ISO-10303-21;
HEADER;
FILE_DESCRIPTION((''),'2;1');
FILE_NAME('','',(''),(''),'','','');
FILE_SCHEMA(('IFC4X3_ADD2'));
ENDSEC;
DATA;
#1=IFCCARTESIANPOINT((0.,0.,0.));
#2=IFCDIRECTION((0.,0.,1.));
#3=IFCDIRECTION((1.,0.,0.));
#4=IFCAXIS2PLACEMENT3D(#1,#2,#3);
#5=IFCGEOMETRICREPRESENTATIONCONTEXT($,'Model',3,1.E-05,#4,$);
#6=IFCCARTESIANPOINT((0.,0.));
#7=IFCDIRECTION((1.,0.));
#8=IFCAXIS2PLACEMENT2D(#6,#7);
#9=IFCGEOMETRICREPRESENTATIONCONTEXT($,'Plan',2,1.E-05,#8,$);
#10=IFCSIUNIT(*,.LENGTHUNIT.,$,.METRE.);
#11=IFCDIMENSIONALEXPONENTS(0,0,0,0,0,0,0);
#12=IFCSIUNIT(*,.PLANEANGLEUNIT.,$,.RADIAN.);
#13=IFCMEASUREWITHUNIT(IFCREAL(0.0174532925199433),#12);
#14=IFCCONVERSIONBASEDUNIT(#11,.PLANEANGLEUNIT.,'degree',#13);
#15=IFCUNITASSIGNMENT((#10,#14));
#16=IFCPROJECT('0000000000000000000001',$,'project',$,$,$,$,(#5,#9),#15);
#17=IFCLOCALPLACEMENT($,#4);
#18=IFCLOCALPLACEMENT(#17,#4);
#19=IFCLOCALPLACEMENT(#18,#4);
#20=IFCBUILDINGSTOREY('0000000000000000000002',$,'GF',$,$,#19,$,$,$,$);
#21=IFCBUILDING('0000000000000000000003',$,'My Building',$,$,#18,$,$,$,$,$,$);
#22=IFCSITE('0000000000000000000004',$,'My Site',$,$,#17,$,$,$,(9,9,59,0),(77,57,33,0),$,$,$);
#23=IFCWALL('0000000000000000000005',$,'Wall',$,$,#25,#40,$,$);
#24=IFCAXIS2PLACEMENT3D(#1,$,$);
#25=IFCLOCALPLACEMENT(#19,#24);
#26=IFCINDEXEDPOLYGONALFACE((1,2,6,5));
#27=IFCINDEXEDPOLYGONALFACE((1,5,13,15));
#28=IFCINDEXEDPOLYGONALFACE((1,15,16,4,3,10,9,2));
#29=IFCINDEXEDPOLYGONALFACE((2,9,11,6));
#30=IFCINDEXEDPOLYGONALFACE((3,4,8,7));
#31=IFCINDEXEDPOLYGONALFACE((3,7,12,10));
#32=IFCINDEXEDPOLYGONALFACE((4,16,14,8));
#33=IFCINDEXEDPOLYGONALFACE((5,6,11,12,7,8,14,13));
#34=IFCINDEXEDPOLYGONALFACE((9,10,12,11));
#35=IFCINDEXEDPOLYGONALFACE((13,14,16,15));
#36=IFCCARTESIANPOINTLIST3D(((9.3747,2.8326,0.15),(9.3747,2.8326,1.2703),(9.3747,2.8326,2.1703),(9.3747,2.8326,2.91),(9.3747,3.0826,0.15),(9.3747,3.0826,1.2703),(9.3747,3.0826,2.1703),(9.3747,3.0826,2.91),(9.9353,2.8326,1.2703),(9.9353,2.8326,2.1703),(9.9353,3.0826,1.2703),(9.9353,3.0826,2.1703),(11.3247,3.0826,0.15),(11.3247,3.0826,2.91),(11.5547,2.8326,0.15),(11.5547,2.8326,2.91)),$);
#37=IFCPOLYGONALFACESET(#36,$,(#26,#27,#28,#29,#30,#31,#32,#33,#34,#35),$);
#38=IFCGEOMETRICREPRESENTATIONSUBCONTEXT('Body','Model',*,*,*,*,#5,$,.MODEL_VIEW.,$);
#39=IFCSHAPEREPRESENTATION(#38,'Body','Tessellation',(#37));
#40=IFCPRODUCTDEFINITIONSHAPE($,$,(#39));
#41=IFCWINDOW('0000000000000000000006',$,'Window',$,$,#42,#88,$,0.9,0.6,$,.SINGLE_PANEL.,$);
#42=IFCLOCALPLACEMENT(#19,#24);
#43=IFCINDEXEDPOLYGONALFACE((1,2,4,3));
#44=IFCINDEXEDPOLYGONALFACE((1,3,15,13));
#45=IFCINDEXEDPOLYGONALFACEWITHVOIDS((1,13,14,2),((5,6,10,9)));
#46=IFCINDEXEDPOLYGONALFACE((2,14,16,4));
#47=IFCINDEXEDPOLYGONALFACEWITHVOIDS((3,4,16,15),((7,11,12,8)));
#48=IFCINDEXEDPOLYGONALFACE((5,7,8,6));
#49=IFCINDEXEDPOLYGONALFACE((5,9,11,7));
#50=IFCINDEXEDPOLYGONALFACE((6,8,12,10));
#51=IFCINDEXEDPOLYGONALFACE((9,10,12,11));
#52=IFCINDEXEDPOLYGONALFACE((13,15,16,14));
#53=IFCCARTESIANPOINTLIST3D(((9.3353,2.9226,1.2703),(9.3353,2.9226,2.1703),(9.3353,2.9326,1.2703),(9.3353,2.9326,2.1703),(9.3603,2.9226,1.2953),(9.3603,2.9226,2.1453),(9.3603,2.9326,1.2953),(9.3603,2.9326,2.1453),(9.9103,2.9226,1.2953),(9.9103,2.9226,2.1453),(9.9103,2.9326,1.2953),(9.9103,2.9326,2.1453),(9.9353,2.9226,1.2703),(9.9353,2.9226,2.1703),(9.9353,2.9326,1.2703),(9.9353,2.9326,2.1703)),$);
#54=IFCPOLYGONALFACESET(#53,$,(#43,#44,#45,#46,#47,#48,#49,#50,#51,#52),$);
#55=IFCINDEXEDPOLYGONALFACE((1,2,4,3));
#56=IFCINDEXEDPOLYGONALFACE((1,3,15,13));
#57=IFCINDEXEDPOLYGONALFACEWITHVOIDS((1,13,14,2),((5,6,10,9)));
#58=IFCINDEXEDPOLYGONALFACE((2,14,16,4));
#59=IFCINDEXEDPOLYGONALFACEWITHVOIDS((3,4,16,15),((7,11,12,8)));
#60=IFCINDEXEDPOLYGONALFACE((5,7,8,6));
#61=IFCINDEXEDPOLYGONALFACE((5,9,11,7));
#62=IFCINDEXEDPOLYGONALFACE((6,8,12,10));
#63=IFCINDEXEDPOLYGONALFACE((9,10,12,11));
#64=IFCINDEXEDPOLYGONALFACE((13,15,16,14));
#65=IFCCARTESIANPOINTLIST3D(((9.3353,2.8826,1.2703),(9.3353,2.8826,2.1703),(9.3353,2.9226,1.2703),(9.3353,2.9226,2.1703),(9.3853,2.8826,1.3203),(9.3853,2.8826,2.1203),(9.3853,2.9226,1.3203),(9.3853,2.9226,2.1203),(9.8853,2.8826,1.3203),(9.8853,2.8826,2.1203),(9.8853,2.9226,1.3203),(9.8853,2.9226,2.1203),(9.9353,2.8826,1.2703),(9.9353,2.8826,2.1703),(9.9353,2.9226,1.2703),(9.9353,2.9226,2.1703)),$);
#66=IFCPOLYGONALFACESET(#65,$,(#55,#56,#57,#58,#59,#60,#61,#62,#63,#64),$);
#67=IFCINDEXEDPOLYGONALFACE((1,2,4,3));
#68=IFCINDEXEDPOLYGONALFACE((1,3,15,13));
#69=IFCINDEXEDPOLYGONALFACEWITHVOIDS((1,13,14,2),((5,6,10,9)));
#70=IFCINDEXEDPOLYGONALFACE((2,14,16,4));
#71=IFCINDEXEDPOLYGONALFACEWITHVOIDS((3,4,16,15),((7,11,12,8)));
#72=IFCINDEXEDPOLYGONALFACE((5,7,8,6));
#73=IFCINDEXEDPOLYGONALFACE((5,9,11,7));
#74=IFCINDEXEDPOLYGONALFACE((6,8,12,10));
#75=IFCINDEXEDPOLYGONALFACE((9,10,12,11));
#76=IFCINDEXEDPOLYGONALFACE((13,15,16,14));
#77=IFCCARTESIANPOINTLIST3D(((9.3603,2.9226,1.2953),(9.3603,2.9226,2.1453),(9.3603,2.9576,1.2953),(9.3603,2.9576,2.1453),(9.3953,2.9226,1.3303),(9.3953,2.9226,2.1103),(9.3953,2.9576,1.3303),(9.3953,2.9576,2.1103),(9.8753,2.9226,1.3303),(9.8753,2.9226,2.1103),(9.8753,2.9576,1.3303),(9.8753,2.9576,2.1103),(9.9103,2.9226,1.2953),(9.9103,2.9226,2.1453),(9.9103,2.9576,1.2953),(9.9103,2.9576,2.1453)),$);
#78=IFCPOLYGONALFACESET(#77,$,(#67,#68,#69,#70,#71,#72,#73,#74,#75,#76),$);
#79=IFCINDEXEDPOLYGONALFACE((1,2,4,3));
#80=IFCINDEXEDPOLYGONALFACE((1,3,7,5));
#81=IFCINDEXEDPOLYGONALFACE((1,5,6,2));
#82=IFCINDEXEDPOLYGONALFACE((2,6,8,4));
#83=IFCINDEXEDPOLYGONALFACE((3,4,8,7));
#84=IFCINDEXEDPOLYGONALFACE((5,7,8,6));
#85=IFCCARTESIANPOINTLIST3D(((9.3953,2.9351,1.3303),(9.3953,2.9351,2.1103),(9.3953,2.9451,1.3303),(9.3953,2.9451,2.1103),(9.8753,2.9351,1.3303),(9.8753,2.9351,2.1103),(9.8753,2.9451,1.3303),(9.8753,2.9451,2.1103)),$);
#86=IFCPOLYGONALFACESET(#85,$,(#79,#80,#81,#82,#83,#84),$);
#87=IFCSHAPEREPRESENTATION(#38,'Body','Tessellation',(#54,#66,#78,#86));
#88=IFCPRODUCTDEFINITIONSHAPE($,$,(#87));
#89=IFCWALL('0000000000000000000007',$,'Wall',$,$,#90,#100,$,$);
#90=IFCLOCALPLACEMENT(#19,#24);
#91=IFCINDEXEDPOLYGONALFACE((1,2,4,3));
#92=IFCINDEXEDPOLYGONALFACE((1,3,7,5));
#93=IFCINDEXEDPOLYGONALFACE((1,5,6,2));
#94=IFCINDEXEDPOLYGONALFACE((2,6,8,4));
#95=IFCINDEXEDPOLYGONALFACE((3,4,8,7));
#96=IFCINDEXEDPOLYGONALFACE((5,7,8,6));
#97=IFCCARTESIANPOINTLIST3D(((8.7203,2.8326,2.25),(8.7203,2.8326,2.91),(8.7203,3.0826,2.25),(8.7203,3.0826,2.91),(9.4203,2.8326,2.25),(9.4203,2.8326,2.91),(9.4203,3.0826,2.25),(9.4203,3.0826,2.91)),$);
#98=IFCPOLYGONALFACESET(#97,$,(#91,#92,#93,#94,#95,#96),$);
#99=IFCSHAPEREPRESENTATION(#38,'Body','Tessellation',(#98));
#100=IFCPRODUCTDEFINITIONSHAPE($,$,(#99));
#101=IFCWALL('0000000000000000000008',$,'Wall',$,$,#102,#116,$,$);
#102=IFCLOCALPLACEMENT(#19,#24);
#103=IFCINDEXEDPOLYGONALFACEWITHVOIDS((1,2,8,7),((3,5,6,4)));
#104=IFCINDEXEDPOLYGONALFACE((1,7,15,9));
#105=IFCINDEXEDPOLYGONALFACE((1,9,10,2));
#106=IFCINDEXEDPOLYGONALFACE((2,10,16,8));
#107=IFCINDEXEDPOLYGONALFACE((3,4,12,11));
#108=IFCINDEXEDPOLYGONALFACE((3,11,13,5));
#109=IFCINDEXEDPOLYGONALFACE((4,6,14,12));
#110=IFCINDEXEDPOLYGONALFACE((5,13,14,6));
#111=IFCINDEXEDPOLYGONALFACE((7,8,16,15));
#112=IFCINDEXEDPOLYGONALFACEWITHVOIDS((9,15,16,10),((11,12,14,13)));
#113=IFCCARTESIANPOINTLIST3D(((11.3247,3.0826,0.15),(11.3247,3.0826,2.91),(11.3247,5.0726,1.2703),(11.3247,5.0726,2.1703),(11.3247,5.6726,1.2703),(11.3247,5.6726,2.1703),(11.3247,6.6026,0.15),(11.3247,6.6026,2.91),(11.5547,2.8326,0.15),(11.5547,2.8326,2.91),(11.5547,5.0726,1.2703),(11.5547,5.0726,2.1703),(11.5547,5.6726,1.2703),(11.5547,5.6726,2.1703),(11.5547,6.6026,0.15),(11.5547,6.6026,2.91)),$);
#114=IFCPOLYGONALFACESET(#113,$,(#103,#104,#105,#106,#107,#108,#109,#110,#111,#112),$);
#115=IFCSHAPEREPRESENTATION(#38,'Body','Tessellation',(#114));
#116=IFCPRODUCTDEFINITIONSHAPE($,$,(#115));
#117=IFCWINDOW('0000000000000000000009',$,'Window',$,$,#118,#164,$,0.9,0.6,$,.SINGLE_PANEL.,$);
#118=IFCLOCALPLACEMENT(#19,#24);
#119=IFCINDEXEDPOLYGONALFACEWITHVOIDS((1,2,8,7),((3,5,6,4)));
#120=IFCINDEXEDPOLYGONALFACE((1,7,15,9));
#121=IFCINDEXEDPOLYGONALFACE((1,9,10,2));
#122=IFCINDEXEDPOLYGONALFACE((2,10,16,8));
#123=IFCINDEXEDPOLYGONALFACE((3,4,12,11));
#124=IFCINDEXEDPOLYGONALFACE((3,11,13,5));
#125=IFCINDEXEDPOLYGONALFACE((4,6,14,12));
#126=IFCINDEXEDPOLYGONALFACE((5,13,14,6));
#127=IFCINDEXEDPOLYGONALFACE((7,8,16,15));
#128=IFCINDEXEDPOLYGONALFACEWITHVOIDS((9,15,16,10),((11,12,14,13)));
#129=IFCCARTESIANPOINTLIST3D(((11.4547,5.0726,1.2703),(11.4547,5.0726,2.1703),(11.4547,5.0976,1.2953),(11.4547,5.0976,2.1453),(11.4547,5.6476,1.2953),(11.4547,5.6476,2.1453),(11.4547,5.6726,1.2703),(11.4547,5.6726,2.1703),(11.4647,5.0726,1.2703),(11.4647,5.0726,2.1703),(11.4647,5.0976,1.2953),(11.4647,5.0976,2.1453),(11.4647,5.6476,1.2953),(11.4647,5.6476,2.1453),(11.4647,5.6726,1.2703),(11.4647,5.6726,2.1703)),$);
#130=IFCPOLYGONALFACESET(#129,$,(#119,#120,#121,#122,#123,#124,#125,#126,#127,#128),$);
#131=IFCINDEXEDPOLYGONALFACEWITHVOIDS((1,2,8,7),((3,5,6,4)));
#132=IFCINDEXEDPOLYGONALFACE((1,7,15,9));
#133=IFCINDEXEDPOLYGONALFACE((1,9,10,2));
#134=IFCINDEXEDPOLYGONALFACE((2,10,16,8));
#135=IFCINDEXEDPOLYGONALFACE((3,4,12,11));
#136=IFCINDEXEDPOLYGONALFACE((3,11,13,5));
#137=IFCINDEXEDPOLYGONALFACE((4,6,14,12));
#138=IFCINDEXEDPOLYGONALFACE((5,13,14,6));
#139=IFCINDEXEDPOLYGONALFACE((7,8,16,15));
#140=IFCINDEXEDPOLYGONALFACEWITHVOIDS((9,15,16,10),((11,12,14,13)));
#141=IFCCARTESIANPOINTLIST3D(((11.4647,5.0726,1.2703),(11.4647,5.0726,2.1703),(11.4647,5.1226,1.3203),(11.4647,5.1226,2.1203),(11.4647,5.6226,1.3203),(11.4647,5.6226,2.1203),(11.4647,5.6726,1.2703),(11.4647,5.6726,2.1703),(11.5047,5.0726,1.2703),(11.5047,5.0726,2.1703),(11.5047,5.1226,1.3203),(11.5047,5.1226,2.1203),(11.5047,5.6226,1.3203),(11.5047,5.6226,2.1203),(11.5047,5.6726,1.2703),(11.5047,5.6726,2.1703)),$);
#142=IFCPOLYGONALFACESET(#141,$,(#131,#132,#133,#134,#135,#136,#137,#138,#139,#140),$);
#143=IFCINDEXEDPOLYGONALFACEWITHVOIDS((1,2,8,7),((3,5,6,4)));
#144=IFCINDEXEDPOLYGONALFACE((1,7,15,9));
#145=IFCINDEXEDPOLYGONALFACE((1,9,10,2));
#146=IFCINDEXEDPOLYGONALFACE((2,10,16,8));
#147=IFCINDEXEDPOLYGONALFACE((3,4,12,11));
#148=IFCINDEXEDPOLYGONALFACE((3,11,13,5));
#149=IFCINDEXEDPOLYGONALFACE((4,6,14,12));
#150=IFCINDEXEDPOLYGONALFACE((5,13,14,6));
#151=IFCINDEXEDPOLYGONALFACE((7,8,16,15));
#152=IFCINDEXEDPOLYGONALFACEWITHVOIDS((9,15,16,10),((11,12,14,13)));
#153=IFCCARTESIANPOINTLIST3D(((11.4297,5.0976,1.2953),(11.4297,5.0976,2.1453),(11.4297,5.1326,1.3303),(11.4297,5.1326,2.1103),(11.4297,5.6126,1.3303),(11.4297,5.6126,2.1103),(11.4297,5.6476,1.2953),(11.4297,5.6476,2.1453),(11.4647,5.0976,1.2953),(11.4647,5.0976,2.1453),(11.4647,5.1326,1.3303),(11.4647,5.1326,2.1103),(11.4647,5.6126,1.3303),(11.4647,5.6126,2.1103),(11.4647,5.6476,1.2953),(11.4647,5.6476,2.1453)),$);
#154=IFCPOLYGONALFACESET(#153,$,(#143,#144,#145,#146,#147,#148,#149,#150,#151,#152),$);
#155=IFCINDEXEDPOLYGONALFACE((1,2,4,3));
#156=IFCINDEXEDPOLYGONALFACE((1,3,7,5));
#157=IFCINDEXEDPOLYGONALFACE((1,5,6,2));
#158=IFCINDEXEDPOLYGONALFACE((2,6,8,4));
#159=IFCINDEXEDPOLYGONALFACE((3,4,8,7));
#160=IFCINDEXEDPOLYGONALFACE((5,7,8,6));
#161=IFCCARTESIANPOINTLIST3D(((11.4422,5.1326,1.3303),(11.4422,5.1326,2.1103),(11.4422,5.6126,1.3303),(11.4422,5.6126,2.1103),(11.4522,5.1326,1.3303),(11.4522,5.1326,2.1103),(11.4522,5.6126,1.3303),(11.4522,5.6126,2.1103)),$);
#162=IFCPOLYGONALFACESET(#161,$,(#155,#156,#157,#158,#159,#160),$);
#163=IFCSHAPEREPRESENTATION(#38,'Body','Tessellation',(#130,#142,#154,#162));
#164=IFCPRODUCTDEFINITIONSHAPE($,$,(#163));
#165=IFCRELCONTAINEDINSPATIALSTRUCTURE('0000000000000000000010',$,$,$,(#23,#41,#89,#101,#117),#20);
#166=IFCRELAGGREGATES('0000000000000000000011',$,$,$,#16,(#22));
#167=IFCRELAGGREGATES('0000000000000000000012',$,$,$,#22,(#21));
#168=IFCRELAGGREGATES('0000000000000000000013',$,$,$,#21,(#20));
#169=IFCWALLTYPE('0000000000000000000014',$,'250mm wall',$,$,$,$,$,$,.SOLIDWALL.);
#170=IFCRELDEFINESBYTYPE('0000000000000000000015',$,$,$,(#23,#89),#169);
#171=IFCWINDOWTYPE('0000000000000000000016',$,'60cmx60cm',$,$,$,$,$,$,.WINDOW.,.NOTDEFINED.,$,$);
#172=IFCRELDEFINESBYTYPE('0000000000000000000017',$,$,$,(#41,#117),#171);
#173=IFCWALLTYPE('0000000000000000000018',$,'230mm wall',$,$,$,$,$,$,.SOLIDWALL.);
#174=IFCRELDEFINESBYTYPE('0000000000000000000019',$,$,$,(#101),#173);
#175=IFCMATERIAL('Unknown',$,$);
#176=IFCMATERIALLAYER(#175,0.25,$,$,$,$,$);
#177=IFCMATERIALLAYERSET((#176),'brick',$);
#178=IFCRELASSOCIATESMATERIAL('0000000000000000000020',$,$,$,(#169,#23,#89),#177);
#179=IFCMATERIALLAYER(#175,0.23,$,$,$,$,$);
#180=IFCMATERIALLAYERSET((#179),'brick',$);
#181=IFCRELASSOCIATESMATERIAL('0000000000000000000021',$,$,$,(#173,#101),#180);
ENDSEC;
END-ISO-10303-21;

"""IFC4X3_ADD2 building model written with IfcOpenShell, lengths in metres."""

from ifc_helpers import new_model, entity, si_unit, converted_unit, frame, origin_with_axes, origin_2d_with_axis, place, context, subcontext, project, spatial, line, indexed_curve, outline, extrude, shape, source, transform, mapped, material, layer, layer_set, layer_usage, type_object, type_shapes, element, fill, save


model = new_model("IFC4X3_ADD2")

# Units and contexts
model_context = context("Model", 3, precision=1e-05, world=origin_with_axes())
plan_context = context("Plan", 2, precision=1e-05, world=origin_2d_with_axis())
body_context_1 = subcontext(model_context, "Body", "Model", "MODEL_VIEW")
body_context_2 = subcontext(plan_context, "Body", "Plan", "PLAN_VIEW")
ifc_project = project(units=[si_unit("LENGTHUNIT", "METRE"), converted_unit("PLANEANGLEUNIT", "degree", entity("IfcReal", 0.0174532925199433), si_unit("PLANEANGLEUNIT", "RADIAN"), dimensions=[0, 0, 0, 0, 0, 0, 0])], contexts=[model_context, plan_context])

# Site, building, storey
site_placement = place(None, origin_with_axes())
site = spatial("IfcSite", under=ifc_project, at=site_placement, Name="My Site", RefLatitude=(9, 9, 59, 0), RefLongitude=(77, 57, 33, 0))
building_placement = place(site_placement, origin_with_axes())
building = spatial("IfcBuilding", under=site, at=building_placement, Name="My Building")
storey_placement = place(building_placement, origin_with_axes())
storey = spatial("IfcBuildingStorey", under=building, at=storey_placement, Name="GF")

# Shared definitions
ifc_material_1 = material(Name="Unknown")
ifc_layer_1 = layer(ifc_material_1, 0.25)
ifc_layer_set_1 = layer_set([ifc_layer_1], Name="brick")
wall_type_1 = type_object("IfcWallType", Name="250mm wall", PredefinedType="SOLIDWALL", material=ifc_layer_set_1)

# Shared definitions
shared_shape_1 = source(origin_with_axes(), body_context_1, "Body", "SweptSolid", [
    extrude(outline(indexed_curve([(0.0, 0.0), (0.6, 0.0), (0.6, 0.9), (0.0, 0.9)], segments=[line(1, 2, 3, 4, 1)])), frame((0.0, -0.6, 0.0), z_axis=(0.0, -1.0, 0.0), x_axis=(1.0, 0.0, 0.0)), (0.0, 0.0, -1.0), 1.2),
])
window_type = type_object("IfcWindowType", Name="60cmx60cm", PartitioningType="NOTDEFINED", PredefinedType="WINDOW")
shared_shape_2 = source(origin_with_axes(), body_context_1, "Body", "SweptSolid", [
    extrude(outline(indexed_curve([(0.0, 0.0), (0.6, 0.0), (0.6, 0.9), (0.0, 0.9)], segments=[line(1, 2, 3, 4, 1)]), holes=[indexed_curve([(0.025, 0.025), (0.575, 0.025), (0.575, 0.875), (0.025, 0.875)], segments=[line(1, 2, 3, 4, 1)])]), frame((0.0, 0.09, 0.0), z_axis=(0.0, -1.0, 0.0), x_axis=(1.0, 0.0, 0.0)), (0.0, 0.0, -1.0), 0.01),
    extrude(outline(indexed_curve([(0.0, 0.0), (0.6, 0.0), (0.6, 0.9), (0.0, 0.9)], segments=[line(1, 2, 3, 4, 1)]), holes=[indexed_curve([(0.05, 0.05), (0.55, 0.05), (0.55, 0.85), (0.05, 0.85)], segments=[line(1, 2, 3, 4, 1)])]), frame((0.0, 0.05, 0.0), z_axis=(0.0, -1.0, 0.0), x_axis=(1.0, 0.0, 0.0)), (0.0, 0.0, -1.0), 0.04),
    extrude(outline(indexed_curve([(0.0, 0.0), (0.55, 0.0), (0.55, 0.85), (0.0, 0.85)], segments=[line(1, 2, 3, 4, 1)]), holes=[indexed_curve([(0.035, 0.035), (0.515, 0.035), (0.515, 0.815), (0.035, 0.815)], segments=[line(1, 2, 3, 4, 1)])]), frame((0.025, 0.09, 0.025), z_axis=(0.0, -1.0, 0.0), x_axis=(1.0, 0.0, 0.0)), (0.0, 0.0, -1.0), 0.035),
    extrude(outline(indexed_curve([(0.035, 0.035), (0.515, 0.035), (0.515, 0.815), (0.035, 0.815)], segments=[line(1, 2, 3, 4, 1)])), frame((0.025, 0.1025, 0.025), z_axis=(0.0, -1.0, 0.0), x_axis=(1.0, 0.0, 0.0)), (0.0, 0.0, -1.0), 0.01),
])
shared_shape_3 = source(origin_with_axes(), body_context_2, "Body", "Curve2D", [
    entity("IfcIndexedPolyCurve", entity("IfcCartesianPointList2D", [[0.05, 0.05], [0.55, 0.05]])),
    entity("IfcIndexedPolyCurve", entity("IfcCartesianPointList2D", [[0.0, 0.1], [0.025, 0.1], [0.025, 0.09], [0.05, 0.09], [0.05, 0.05], [0.0, 0.05]]), [entity("IfcLineIndex", [1, 2, 3, 4, 5, 6, 1])]),
    entity("IfcIndexedPolyCurve", entity("IfcCartesianPointList2D", [[0.6, 0.1], [0.575, 0.1], [0.575, 0.09], [0.55, 0.09], [0.55, 0.05], [0.6, 0.05]]), [entity("IfcLineIndex", [1, 2, 3, 4, 5, 6, 1])]),
    entity("IfcIndexedPolyCurve", entity("IfcCartesianPointList2D", [[0.025, 0.09], [0.06, 0.09], [0.06, 0.125], [0.025, 0.125]]), [entity("IfcLineIndex", [1, 2, 3, 4, 1])]),
    entity("IfcIndexedPolyCurve", entity("IfcCartesianPointList2D", [[0.575, 0.09], [0.54, 0.09], [0.54, 0.125], [0.575, 0.125]]), [entity("IfcLineIndex", [1, 2, 3, 4, 1])]),
    entity("IfcIndexedPolyCurve", entity("IfcCartesianPointList2D", [[0.06, 0.09], [0.54, 0.09]])),
    entity("IfcIndexedPolyCurve", entity("IfcCartesianPointList2D", [[0.06, 0.125], [0.54, 0.125]])),
    entity("IfcIndexedPolyCurve", entity("IfcCartesianPointList2D", [[0.06, 0.1075], [0.54, 0.1075]])),
])
type_shapes(window_type, [shared_shape_2, shared_shape_3])

# Wall, opening, window
ifc_layer_usage_1 = layer_usage(ifc_layer_set_1, "AXIS2", "POSITIVE", 0.0)
wall_1_placement = place(storey_placement, frame((9.3747, 2.8326, 0.15), z_axis=(0.0, 0.0, 1.0), x_axis=(1.0, 0.0, 0.0)))
wall_1 = element("IfcWall", 1, at=wall_1_placement, inside=storey, type_object=wall_type_1, material=ifc_layer_usage_1, Name="Wall", context=body_context_1, shape_type="SweptSolid", body=[
    extrude(outline(indexed_curve([(0.0, 0.0), (0.0, 0.25), (1.95, 0.25), (2.18, 0.0)], segments=[line(1, 2, 3, 4, 1)])), origin_with_axes(), (0.0, 0.0, 1.0), 2.76),
])
opening_1_placement = place(wall_1_placement, frame((-0.0393, 0.0, 1.1203), z_axis=(0.0, 0.0, 1.0), x_axis=(1.0, 0.0, 0.0)))
opening_1 = element("IfcOpeningElement", 2, at=opening_1_placement, cuts=wall_1, PredefinedType="OPENING", context=body_context_1, shape_type="MappedRepresentation", body=[
    mapped(shared_shape_1, transform((0.0, 0.0, 0.0), x_axis=(1.0, 0.0, 0.0), y_axis=(0.0, 1.0, 0.0), z_axis=(0.0, 0.0, 1.0), scale=1.0)),
])
window_1_placement = place(storey_placement, frame((9.3353, 2.8326, 1.2703), z_axis=(0.0, 0.0, 1.0), x_axis=(1.0, 0.0, 0.0)))
window_1 = element("IfcWindow", 3, at=window_1_placement, inside=storey, type_object=window_type, Name="Window", OverallHeight=0.9, OverallWidth=0.6, PartitioningType="SINGLE_PANEL", shapes=[
    shape(body_context_1, "Body", "MappedRepresentation", [mapped(shared_shape_2, transform((0.0, 0.0, 0.0), x_axis=(1.0, 0.0, 0.0), y_axis=(0.0, 1.0, 0.0), z_axis=(0.0, 0.0, 1.0), scale=1.0))]),
    shape(body_context_2, "Body", "MappedRepresentation", [mapped(shared_shape_3, transform((0.0, 0.0, 0.0), x_axis=(1.0, 0.0, 0.0), y_axis=(0.0, 1.0, 0.0), z_axis=(0.0, 0.0, 1.0), scale=1.0))]),
])
fill(opening_1, window_1)

# Wall
ifc_layer_usage_2 = layer_usage(ifc_layer_set_1, "AXIS2", "POSITIVE", 0.0)
wall_2_placement = place(storey_placement, frame((8.7203, 2.8326, 2.25), z_axis=(0.0, 0.0, 1.0), x_axis=(1.0, 0.0, 0.0)))
element("IfcWall", 4, at=wall_2_placement, inside=storey, type_object=wall_type_1, material=ifc_layer_usage_2, Name="Wall", context=body_context_1, shape_type="SweptSolid", body=[
    extrude(outline(indexed_curve([(0.0, 0.0), (0.0, 0.25), (0.7, 0.25), (0.7, 0.0)], segments=[line(1, 2, 3, 4, 1)])), origin_with_axes(), (0.0, 0.0, 1.0), 0.66),
])

# Wall, opening, window
ifc_layer_2 = layer(ifc_material_1, 0.23)
ifc_layer_set_2 = layer_set([ifc_layer_2], Name="brick")
ifc_layer_usage_3 = layer_usage(ifc_layer_set_2, "AXIS2", "POSITIVE", 0.0)
wall_type_2 = type_object("IfcWallType", Name="230mm wall", PredefinedType="SOLIDWALL", material=ifc_layer_set_2)
wall_3_placement = place(storey_placement, frame((11.5547, 2.8326, 0.15), z_axis=(0.0, 0.0, 1.0), x_axis=(0.0, 1.0, 0.0)))
wall_3 = element("IfcWall", 5, at=wall_3_placement, inside=storey, type_object=wall_type_2, material=ifc_layer_usage_3, Name="Wall", context=body_context_1, shape_type="SweptSolid", body=[
    extrude(outline(indexed_curve([(0.0, 0.0), (0.25, 0.23), (3.77, 0.23), (3.77, 0.0)], segments=[line(1, 2, 3, 4, 1)])), origin_with_axes(), (0.0, 0.0, 1.0), 2.76),
])
opening_2_placement = place(wall_3_placement, frame((2.24, 0.0, 1.1203), z_axis=(0.0, 0.0, 1.0), x_axis=(1.0, 0.0, 0.0)))
opening_2 = element("IfcOpeningElement", 6, at=opening_2_placement, cuts=wall_3, PredefinedType="OPENING", context=body_context_1, shape_type="MappedRepresentation", body=[
    mapped(shared_shape_1, transform((0.0, 0.0, 0.0), x_axis=(1.0, 0.0, 0.0), y_axis=(0.0, 1.0, 0.0), z_axis=(0.0, 0.0, 1.0), scale=1.0)),
])
placement = place(wall_3_placement, frame((2.24, 0.0, 1.1203), z_axis=(0.0, 0.0, 1.0), x_axis=(1.0, 0.0, 0.0)))
window_2_placement = place(placement, frame((0.0, 0.0, 0.0), z_axis=(0.0, 0.0, 1.0), x_axis=(1.0, 0.0, 0.0)))
window_2 = element("IfcWindow", 7, at=window_2_placement, inside=storey, type_object=window_type, Name="Window", OverallHeight=0.9, OverallWidth=0.6, PartitioningType="SINGLE_PANEL", shapes=[
    shape(body_context_1, "Body", "MappedRepresentation", [mapped(shared_shape_2, transform((0.0, 0.0, 0.0), x_axis=(1.0, 0.0, 0.0), y_axis=(0.0, 1.0, 0.0), z_axis=(0.0, 0.0, 1.0), scale=1.0))]),
    shape(body_context_2, "Body", "MappedRepresentation", [mapped(shared_shape_3, transform((0.0, 0.0, 0.0), x_axis=(1.0, 0.0, 0.0), y_axis=(0.0, 1.0, 0.0), z_axis=(0.0, 0.0, 1.0), scale=1.0))]),
])
fill(opening_2, window_2)

save(model, "model.ifc")
